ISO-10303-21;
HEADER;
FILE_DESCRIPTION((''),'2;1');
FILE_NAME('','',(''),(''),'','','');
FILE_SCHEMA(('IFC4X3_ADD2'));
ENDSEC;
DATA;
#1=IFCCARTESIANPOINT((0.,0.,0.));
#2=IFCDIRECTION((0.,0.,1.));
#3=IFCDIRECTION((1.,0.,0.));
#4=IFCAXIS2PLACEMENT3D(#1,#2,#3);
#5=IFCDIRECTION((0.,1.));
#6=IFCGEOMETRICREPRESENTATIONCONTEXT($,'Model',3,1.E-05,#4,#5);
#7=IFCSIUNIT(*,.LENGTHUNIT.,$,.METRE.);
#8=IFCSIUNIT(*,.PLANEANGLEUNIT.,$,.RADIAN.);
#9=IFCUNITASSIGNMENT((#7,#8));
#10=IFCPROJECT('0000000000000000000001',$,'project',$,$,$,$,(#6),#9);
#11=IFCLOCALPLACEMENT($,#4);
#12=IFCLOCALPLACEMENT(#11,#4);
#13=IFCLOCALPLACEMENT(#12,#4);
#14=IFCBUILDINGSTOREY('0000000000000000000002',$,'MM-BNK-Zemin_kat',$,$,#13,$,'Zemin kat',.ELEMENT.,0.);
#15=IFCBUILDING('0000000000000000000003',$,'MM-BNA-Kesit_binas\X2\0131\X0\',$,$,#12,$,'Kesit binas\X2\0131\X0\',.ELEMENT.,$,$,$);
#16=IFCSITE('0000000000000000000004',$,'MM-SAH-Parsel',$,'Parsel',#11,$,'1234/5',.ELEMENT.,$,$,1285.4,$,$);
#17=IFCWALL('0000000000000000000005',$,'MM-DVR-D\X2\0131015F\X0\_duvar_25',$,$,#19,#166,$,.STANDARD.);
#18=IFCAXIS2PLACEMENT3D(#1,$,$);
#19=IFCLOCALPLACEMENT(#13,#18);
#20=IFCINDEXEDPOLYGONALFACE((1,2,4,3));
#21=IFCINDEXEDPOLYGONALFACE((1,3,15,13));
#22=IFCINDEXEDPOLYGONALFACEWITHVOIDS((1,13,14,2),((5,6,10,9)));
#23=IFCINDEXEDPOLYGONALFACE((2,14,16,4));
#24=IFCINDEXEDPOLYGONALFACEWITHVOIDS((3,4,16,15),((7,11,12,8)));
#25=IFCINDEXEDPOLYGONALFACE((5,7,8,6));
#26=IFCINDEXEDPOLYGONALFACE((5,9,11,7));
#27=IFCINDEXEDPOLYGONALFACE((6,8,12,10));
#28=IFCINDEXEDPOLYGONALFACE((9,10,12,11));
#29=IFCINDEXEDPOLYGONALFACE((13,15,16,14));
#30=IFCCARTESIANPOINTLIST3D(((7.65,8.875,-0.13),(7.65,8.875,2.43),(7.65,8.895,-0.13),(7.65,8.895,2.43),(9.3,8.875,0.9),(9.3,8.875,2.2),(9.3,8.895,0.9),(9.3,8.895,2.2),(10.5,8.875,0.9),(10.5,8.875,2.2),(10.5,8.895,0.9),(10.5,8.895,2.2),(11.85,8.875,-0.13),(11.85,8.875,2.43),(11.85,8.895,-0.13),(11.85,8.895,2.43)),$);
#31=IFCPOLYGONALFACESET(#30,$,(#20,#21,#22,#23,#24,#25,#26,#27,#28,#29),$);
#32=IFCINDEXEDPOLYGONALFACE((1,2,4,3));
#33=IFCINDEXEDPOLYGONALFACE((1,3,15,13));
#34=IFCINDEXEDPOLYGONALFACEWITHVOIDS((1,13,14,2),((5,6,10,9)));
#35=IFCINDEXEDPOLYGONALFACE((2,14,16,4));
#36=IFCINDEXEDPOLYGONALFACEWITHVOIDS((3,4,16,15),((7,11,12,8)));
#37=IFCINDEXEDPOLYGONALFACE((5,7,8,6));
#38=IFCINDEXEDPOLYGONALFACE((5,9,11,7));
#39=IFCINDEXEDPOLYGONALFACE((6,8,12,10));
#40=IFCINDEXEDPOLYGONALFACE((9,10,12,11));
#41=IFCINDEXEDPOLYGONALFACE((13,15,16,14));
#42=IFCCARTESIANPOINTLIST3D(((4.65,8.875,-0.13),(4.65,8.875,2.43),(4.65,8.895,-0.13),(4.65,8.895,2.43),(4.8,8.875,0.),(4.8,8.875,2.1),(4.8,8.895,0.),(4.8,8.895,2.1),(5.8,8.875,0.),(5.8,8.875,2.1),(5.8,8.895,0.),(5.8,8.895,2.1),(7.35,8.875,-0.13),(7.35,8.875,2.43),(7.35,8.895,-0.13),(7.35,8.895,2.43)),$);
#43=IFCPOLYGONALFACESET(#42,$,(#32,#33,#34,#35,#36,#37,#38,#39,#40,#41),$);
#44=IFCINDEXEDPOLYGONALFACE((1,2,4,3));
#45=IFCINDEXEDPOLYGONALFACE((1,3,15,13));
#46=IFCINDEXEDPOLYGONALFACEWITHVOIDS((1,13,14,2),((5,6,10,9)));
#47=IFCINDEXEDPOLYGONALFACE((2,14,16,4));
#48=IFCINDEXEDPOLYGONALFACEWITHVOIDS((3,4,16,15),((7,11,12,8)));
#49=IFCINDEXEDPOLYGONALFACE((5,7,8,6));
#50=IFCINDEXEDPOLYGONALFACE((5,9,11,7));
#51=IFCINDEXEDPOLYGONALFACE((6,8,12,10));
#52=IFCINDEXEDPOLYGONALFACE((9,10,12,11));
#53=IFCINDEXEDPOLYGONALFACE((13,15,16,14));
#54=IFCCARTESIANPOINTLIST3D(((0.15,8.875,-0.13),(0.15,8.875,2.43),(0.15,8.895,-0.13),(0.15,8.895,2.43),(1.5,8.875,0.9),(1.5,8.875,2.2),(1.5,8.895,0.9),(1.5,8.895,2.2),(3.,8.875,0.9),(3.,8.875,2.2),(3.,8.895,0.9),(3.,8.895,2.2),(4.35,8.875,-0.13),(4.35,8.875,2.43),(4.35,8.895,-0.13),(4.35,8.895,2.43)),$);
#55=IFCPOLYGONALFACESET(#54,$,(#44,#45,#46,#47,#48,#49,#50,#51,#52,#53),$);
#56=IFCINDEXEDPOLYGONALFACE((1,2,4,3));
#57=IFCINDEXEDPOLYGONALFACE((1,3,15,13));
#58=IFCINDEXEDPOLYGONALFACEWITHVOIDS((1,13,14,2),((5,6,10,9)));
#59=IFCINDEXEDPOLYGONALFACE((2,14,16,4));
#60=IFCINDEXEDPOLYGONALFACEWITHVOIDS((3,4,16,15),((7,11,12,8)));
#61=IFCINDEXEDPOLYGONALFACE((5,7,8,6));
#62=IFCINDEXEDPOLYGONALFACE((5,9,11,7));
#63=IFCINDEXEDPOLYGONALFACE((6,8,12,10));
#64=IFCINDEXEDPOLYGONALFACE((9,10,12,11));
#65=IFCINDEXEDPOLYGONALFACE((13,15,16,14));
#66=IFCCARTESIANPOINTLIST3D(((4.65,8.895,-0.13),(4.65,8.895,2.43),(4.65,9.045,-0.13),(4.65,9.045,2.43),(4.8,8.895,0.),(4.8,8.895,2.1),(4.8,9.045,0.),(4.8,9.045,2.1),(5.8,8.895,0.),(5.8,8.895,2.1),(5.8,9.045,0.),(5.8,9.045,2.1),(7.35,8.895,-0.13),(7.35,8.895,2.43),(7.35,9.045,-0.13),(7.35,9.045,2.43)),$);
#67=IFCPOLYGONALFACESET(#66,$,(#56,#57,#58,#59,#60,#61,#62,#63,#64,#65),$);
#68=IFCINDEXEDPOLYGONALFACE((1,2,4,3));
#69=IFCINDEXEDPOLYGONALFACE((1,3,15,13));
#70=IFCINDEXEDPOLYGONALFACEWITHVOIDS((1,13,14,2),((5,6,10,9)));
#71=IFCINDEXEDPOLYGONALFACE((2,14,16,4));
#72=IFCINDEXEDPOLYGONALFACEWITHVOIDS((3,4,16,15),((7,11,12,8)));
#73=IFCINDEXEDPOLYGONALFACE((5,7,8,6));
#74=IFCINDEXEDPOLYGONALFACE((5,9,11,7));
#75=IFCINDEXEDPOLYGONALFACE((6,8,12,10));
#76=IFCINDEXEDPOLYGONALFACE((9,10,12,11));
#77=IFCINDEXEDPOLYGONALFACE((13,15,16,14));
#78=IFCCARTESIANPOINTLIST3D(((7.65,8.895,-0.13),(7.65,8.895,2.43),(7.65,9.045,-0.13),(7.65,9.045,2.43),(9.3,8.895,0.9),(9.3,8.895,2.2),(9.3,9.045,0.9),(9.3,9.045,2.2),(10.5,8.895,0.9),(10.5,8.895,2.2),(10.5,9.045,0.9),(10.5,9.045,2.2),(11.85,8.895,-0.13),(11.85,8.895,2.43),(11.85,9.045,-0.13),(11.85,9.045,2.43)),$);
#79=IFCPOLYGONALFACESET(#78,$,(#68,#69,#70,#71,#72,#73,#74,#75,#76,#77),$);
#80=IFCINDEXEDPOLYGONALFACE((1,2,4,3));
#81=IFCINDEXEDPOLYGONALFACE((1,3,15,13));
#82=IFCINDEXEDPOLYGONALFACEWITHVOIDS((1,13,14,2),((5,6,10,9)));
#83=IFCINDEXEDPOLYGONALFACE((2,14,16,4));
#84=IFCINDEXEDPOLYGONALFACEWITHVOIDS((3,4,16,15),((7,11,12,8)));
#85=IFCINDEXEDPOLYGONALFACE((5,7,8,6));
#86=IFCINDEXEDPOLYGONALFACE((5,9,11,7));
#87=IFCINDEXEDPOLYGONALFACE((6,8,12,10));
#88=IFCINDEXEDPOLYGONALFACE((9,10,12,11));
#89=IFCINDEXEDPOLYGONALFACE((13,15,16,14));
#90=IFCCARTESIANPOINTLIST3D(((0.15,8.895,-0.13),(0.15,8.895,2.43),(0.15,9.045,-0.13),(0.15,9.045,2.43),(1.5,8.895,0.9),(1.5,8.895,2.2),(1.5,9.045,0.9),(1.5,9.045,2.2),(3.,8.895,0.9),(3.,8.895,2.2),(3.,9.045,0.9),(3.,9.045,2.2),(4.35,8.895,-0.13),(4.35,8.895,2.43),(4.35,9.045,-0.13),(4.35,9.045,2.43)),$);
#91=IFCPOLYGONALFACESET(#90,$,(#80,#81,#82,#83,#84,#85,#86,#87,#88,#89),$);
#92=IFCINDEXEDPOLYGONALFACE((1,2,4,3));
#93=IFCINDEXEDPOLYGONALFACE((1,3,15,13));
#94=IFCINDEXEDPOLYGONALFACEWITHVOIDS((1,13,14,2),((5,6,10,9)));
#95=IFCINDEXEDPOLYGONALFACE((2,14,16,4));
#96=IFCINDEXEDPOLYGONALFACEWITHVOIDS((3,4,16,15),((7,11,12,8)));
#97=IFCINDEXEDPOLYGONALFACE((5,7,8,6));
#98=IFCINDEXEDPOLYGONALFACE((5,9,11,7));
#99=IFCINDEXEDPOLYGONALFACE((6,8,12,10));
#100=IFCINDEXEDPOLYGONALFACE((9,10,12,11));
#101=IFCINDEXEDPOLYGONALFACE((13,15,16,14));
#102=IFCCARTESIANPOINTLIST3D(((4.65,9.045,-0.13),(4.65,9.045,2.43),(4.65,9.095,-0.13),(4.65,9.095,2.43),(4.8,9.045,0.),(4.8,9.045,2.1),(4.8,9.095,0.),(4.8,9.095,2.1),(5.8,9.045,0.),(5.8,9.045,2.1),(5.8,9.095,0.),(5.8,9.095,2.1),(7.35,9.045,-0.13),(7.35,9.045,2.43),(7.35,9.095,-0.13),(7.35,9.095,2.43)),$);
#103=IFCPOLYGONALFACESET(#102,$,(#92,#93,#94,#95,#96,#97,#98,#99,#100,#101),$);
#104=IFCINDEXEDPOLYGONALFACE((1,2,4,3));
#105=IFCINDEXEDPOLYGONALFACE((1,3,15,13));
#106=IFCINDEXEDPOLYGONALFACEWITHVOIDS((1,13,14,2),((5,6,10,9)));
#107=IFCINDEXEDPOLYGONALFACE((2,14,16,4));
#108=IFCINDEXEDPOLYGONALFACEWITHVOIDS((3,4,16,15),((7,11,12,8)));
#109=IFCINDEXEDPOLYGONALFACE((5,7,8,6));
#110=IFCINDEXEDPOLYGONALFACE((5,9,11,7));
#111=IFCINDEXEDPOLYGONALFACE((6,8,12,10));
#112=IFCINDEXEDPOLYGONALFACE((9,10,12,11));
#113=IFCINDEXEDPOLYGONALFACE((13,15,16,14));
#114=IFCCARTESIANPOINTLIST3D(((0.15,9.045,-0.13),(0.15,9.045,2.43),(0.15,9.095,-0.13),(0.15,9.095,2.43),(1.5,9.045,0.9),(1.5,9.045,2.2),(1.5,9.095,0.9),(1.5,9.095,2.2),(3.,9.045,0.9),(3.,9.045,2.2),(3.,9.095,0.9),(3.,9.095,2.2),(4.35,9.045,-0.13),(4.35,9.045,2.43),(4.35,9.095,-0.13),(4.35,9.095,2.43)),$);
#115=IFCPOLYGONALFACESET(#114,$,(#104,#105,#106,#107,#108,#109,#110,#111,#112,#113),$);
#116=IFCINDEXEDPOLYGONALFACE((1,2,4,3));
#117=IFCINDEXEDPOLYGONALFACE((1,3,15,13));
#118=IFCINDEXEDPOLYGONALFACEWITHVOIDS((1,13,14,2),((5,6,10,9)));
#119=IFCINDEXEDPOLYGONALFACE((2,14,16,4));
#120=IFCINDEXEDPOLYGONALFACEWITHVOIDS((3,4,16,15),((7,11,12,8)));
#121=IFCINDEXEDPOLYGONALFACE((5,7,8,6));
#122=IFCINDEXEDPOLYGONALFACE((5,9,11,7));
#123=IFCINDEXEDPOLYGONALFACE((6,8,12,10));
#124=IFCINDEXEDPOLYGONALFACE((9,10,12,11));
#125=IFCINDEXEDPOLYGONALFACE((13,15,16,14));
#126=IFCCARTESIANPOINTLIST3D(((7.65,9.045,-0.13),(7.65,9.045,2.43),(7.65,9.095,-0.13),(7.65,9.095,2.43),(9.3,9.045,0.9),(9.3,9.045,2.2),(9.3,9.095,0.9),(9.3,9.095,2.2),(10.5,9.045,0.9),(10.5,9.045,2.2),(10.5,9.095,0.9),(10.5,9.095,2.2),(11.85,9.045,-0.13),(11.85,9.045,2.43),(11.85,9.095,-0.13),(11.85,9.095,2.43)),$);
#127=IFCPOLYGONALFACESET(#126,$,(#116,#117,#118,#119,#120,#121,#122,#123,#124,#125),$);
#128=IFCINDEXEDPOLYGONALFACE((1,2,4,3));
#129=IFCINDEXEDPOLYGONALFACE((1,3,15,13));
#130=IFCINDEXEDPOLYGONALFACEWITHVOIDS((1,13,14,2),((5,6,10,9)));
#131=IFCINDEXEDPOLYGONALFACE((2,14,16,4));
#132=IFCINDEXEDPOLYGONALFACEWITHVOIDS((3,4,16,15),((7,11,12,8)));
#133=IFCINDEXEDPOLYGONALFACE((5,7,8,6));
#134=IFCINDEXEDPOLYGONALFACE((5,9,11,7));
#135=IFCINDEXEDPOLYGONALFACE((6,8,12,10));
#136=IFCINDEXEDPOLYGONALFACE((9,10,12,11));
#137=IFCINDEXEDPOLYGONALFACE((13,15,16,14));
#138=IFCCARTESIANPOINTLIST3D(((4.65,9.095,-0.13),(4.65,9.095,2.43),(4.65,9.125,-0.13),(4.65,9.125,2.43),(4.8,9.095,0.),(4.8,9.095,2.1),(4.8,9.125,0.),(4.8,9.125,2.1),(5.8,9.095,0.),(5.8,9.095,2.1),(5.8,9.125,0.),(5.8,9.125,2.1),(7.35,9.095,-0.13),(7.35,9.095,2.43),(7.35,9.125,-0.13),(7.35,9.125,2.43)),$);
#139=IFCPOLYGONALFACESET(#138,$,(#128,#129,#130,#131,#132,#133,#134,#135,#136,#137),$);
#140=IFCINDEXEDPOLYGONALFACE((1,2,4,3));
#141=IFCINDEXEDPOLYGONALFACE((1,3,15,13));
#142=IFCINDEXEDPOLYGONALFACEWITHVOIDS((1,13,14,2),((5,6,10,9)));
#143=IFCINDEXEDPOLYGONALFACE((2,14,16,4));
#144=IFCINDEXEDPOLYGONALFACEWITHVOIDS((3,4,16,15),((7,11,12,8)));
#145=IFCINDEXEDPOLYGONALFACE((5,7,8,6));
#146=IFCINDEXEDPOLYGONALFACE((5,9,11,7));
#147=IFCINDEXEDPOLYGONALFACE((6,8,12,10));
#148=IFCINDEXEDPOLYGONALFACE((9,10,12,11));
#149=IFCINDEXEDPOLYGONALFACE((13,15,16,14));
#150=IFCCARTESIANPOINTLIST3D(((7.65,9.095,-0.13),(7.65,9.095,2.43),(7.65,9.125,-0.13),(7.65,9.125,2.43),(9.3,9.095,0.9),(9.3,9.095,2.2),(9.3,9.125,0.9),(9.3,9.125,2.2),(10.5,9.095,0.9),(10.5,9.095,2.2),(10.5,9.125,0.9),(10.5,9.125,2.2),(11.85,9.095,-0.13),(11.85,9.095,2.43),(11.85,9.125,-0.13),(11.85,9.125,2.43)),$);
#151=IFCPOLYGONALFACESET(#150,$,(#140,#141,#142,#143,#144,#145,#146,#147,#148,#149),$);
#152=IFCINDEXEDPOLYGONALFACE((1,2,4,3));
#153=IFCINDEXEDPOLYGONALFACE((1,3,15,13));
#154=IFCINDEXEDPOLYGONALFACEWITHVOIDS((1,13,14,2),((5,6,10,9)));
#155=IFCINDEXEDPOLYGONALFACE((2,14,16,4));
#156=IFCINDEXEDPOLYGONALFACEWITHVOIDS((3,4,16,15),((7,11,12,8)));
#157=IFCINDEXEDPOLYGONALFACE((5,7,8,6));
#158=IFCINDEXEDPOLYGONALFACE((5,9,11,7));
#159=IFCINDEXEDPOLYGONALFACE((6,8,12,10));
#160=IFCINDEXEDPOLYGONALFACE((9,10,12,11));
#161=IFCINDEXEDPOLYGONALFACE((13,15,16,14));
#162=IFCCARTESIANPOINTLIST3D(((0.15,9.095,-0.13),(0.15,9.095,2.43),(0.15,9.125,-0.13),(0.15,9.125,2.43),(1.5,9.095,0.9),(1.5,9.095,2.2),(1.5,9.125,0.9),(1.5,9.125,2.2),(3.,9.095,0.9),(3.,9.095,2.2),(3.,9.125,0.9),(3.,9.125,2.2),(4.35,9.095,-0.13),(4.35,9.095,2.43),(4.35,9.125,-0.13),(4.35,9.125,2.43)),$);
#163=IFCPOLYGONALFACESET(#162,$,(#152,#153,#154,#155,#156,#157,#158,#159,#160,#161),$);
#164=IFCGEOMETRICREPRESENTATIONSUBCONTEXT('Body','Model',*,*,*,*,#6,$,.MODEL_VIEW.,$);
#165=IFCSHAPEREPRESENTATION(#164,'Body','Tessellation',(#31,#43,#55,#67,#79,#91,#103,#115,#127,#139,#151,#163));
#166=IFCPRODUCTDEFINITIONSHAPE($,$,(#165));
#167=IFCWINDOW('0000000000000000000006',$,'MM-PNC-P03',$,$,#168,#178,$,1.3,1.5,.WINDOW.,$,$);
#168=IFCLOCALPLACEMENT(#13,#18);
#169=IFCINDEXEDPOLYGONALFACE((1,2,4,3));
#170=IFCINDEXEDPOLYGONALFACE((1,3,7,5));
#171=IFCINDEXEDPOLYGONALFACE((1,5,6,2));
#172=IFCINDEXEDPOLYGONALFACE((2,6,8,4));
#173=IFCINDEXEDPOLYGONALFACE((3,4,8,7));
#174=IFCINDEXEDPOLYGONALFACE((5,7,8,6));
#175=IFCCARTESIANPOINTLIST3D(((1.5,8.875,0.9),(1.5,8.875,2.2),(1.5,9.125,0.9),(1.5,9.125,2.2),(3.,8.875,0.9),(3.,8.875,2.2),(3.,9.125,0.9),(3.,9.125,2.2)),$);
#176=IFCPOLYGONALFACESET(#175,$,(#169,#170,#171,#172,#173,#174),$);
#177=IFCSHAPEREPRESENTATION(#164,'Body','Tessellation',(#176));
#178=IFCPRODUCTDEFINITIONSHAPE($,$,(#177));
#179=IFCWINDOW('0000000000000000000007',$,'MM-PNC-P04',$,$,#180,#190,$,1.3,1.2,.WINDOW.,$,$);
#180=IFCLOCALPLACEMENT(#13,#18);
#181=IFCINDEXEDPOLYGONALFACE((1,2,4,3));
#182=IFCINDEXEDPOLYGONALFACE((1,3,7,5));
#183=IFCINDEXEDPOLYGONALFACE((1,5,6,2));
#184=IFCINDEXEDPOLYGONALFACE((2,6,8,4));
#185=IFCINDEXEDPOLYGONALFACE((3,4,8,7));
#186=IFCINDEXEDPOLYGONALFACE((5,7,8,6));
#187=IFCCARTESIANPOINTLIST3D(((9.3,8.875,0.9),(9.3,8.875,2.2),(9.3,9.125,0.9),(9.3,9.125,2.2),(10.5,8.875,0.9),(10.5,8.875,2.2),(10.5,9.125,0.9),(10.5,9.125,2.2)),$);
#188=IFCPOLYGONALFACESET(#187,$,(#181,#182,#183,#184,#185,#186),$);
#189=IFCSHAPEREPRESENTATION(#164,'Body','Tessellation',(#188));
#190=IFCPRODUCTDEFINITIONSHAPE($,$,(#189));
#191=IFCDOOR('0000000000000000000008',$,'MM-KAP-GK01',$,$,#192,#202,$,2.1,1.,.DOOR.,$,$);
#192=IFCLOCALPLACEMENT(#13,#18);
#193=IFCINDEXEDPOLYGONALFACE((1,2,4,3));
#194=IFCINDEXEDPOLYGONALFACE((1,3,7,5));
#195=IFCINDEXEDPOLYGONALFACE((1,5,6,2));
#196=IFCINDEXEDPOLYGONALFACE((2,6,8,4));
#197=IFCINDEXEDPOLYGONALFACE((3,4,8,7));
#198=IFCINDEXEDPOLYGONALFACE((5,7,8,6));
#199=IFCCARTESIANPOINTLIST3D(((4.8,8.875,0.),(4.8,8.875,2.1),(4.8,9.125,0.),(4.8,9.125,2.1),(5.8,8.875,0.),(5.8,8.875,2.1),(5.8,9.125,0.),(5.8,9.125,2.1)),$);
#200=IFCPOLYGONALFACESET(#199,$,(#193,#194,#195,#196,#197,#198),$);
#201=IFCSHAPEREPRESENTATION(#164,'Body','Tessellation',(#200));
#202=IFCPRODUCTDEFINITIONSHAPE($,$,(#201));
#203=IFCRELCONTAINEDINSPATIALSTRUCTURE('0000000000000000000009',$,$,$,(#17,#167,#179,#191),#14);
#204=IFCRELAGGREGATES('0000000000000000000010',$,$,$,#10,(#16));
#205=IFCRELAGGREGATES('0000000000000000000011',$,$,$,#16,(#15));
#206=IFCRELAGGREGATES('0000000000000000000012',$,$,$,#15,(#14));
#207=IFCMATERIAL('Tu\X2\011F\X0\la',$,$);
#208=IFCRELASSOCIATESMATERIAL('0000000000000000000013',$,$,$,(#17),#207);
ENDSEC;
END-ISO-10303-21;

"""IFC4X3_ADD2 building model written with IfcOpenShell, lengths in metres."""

from ifc_helpers import new_model, si_unit, direction, frame, origin, origin_with_axes, place, context, subcontext, project, spatial, polyline, outline, extrude, material, element, fill, save


model = new_model("IFC4X3_ADD2")

# Units and contexts
model_context = context("Model", 3, precision=1e-05, world=origin_with_axes(), true_north=direction((0.0, 1.0)))
body_context = subcontext(model_context, "Body", "Model", "MODEL_VIEW")
ifc_project = project(units=[si_unit("LENGTHUNIT", "METRE"), si_unit("PLANEANGLEUNIT", "RADIAN")], contexts=[model_context])

# Site, building, storey
site_placement = place(None, origin_with_axes())
site = spatial("IfcSite", under=ifc_project, at=site_placement, Name="MM-SAH-Parsel", ObjectType="Parsel", LongName="1234/5", CompositionType="ELEMENT", RefElevation=1285.4)
building_placement = place(site_placement, origin_with_axes())
building = spatial("IfcBuilding", under=site, at=building_placement, Name="MM-BNA-Kesit_binası", LongName="Kesit binası", CompositionType="ELEMENT")
storey_placement = place(building_placement, origin_with_axes())
storey = spatial("IfcBuildingStorey", under=building, at=storey_placement, Name="MM-BNK-Zemin_kat", LongName="Zemin kat", CompositionType="ELEMENT", Elevation=0.0)

# Shared definitions
ifc_material_1 = material(Name="Tuğla")

# Wall, openings, windows, door
wall_1_placement = place(storey_placement, origin_with_axes())
wall_1 = element("IfcWall", 1, at=wall_1_placement, inside=storey, material=ifc_material_1, Name="MM-DVR-Dış_duvar_25", PredefinedType="STANDARD", context=body_context, shape_type="SweptSolid", body=[
    extrude(outline(polyline([(11.85, 8.895), (7.65, 8.895), (7.65, 8.875), (11.85, 8.875), (11.85, 8.895)])), frame((0.0, 0.0, -0.13)), (0.0, 0.0, 1.0), 2.56),
    extrude(outline(polyline([(7.35, 8.895), (4.65, 8.895), (4.65, 8.875), (7.35, 8.875), (7.35, 8.895)])), frame((0.0, 0.0, -0.13)), (0.0, 0.0, 1.0), 2.56),
    extrude(outline(polyline([(4.35, 8.895), (0.15, 8.895), (0.15, 8.875), (4.35, 8.875), (4.35, 8.895)])), frame((0.0, 0.0, -0.13)), (0.0, 0.0, 1.0), 2.56),
    extrude(outline(polyline([(7.35, 9.045), (4.65, 9.045), (4.65, 8.895), (7.35, 8.895), (7.35, 9.045)])), frame((0.0, 0.0, -0.13)), (0.0, 0.0, 1.0), 2.56),
    extrude(outline(polyline([(11.85, 9.045), (7.65, 9.045), (7.65, 8.895), (11.85, 8.895), (11.85, 9.045)])), frame((0.0, 0.0, -0.13)), (0.0, 0.0, 1.0), 2.56),
    extrude(outline(polyline([(4.35, 9.045), (0.15, 9.045), (0.15, 8.895), (4.35, 8.895), (4.35, 9.045)])), frame((0.0, 0.0, -0.13)), (0.0, 0.0, 1.0), 2.56),
    extrude(outline(polyline([(7.35, 9.095), (4.65, 9.095), (4.65, 9.045), (7.35, 9.045), (7.35, 9.095)])), frame((0.0, 0.0, -0.13)), (0.0, 0.0, 1.0), 2.56),
    extrude(outline(polyline([(4.35, 9.095), (0.15, 9.095), (0.15, 9.045), (4.35, 9.045), (4.35, 9.095)])), frame((0.0, 0.0, -0.13)), (0.0, 0.0, 1.0), 2.56),
    extrude(outline(polyline([(11.85, 9.095), (7.65, 9.095), (7.65, 9.045), (11.85, 9.045), (11.85, 9.095)])), frame((0.0, 0.0, -0.13)), (0.0, 0.0, 1.0), 2.56),
    extrude(outline(polyline([(7.35, 9.125), (4.65, 9.125), (4.65, 9.095), (7.35, 9.095), (7.35, 9.125)])), frame((0.0, 0.0, -0.13)), (0.0, 0.0, 1.0), 2.56),
    extrude(outline(polyline([(11.85, 9.125), (7.65, 9.125), (7.65, 9.095), (11.85, 9.095), (11.85, 9.125)])), frame((0.0, 0.0, -0.13)), (0.0, 0.0, 1.0), 2.56),
    extrude(outline(polyline([(4.35, 9.125), (0.15, 9.125), (0.15, 9.095), (4.35, 9.095), (4.35, 9.125)])), frame((0.0, 0.0, -0.13)), (0.0, 0.0, 1.0), 2.56),
])
opening_1_placement = place(storey_placement, origin_with_axes())
opening_1 = element("IfcOpeningElement", 2, at=opening_1_placement, cuts=wall_1, PredefinedType="OPENING", context=body_context, shape_type="SweptSolid", body=[
    extrude(outline(polyline([(3.0, 8.875), (1.5, 8.875), (1.5, 9.125), (3.0, 9.125), (3.0, 8.875)])), frame((0.0, 0.0, 0.9)), (0.0, 0.0, 1.0), 1.3),
])
opening_2_placement = place(storey_placement, origin_with_axes())
opening_2 = element("IfcOpeningElement", 3, at=opening_2_placement, cuts=wall_1, PredefinedType="OPENING", context=body_context, shape_type="SweptSolid", body=[
    extrude(outline(polyline([(10.5, 8.875), (9.3, 8.875), (9.3, 9.125), (10.5, 9.125), (10.5, 8.875)])), frame((0.0, 0.0, 0.9)), (0.0, 0.0, 1.0), 1.3),
])
opening_3_placement = place(storey_placement, origin_with_axes())
opening_3 = element("IfcOpeningElement", 4, at=opening_3_placement, cuts=wall_1, PredefinedType="OPENING", context=body_context, shape_type="SweptSolid", body=[
    extrude(outline(polyline([(5.8, 8.875), (4.8, 8.875), (4.8, 9.125), (5.8, 9.125), (5.8, 8.875)])), origin(), (0.0, 0.0, 1.0), 2.1),
])
window_1_placement = place(storey_placement, origin_with_axes())
window_1 = element("IfcWindow", 5, at=window_1_placement, inside=storey, Name="MM-PNC-P03", OverallHeight=1.3, OverallWidth=1.5, PredefinedType="WINDOW", context=body_context, shape_type="SweptSolid", body=[
    extrude(outline(polyline([(3.0, 8.875), (1.5, 8.875), (1.5, 9.125), (3.0, 9.125), (3.0, 8.875)])), frame((0.0, 0.0, 0.9)), (0.0, 0.0, 1.0), 1.3),
])
fill(opening_1, window_1)
window_2_placement = place(storey_placement, origin_with_axes())
window_2 = element("IfcWindow", 6, at=window_2_placement, inside=storey, Name="MM-PNC-P04", OverallHeight=1.3, OverallWidth=1.2, PredefinedType="WINDOW", context=body_context, shape_type="SweptSolid", body=[
    extrude(outline(polyline([(10.5, 8.875), (9.3, 8.875), (9.3, 9.125), (10.5, 9.125), (10.5, 8.875)])), frame((0.0, 0.0, 0.9)), (0.0, 0.0, 1.0), 1.3),
])
fill(opening_2, window_2)
door_1_placement = place(storey_placement, origin_with_axes())
door_1 = element("IfcDoor", 7, at=door_1_placement, inside=storey, Name="MM-KAP-GK01", OverallHeight=2.1, OverallWidth=1.0, PredefinedType="DOOR", context=body_context, shape_type="SweptSolid", body=[
    extrude(outline(polyline([(5.8, 8.875), (4.8, 8.875), (4.8, 9.125), (5.8, 9.125), (5.8, 8.875)])), origin(), (0.0, 0.0, 1.0), 2.1),
])
fill(opening_3, door_1)

save(model, "model.ifc")
